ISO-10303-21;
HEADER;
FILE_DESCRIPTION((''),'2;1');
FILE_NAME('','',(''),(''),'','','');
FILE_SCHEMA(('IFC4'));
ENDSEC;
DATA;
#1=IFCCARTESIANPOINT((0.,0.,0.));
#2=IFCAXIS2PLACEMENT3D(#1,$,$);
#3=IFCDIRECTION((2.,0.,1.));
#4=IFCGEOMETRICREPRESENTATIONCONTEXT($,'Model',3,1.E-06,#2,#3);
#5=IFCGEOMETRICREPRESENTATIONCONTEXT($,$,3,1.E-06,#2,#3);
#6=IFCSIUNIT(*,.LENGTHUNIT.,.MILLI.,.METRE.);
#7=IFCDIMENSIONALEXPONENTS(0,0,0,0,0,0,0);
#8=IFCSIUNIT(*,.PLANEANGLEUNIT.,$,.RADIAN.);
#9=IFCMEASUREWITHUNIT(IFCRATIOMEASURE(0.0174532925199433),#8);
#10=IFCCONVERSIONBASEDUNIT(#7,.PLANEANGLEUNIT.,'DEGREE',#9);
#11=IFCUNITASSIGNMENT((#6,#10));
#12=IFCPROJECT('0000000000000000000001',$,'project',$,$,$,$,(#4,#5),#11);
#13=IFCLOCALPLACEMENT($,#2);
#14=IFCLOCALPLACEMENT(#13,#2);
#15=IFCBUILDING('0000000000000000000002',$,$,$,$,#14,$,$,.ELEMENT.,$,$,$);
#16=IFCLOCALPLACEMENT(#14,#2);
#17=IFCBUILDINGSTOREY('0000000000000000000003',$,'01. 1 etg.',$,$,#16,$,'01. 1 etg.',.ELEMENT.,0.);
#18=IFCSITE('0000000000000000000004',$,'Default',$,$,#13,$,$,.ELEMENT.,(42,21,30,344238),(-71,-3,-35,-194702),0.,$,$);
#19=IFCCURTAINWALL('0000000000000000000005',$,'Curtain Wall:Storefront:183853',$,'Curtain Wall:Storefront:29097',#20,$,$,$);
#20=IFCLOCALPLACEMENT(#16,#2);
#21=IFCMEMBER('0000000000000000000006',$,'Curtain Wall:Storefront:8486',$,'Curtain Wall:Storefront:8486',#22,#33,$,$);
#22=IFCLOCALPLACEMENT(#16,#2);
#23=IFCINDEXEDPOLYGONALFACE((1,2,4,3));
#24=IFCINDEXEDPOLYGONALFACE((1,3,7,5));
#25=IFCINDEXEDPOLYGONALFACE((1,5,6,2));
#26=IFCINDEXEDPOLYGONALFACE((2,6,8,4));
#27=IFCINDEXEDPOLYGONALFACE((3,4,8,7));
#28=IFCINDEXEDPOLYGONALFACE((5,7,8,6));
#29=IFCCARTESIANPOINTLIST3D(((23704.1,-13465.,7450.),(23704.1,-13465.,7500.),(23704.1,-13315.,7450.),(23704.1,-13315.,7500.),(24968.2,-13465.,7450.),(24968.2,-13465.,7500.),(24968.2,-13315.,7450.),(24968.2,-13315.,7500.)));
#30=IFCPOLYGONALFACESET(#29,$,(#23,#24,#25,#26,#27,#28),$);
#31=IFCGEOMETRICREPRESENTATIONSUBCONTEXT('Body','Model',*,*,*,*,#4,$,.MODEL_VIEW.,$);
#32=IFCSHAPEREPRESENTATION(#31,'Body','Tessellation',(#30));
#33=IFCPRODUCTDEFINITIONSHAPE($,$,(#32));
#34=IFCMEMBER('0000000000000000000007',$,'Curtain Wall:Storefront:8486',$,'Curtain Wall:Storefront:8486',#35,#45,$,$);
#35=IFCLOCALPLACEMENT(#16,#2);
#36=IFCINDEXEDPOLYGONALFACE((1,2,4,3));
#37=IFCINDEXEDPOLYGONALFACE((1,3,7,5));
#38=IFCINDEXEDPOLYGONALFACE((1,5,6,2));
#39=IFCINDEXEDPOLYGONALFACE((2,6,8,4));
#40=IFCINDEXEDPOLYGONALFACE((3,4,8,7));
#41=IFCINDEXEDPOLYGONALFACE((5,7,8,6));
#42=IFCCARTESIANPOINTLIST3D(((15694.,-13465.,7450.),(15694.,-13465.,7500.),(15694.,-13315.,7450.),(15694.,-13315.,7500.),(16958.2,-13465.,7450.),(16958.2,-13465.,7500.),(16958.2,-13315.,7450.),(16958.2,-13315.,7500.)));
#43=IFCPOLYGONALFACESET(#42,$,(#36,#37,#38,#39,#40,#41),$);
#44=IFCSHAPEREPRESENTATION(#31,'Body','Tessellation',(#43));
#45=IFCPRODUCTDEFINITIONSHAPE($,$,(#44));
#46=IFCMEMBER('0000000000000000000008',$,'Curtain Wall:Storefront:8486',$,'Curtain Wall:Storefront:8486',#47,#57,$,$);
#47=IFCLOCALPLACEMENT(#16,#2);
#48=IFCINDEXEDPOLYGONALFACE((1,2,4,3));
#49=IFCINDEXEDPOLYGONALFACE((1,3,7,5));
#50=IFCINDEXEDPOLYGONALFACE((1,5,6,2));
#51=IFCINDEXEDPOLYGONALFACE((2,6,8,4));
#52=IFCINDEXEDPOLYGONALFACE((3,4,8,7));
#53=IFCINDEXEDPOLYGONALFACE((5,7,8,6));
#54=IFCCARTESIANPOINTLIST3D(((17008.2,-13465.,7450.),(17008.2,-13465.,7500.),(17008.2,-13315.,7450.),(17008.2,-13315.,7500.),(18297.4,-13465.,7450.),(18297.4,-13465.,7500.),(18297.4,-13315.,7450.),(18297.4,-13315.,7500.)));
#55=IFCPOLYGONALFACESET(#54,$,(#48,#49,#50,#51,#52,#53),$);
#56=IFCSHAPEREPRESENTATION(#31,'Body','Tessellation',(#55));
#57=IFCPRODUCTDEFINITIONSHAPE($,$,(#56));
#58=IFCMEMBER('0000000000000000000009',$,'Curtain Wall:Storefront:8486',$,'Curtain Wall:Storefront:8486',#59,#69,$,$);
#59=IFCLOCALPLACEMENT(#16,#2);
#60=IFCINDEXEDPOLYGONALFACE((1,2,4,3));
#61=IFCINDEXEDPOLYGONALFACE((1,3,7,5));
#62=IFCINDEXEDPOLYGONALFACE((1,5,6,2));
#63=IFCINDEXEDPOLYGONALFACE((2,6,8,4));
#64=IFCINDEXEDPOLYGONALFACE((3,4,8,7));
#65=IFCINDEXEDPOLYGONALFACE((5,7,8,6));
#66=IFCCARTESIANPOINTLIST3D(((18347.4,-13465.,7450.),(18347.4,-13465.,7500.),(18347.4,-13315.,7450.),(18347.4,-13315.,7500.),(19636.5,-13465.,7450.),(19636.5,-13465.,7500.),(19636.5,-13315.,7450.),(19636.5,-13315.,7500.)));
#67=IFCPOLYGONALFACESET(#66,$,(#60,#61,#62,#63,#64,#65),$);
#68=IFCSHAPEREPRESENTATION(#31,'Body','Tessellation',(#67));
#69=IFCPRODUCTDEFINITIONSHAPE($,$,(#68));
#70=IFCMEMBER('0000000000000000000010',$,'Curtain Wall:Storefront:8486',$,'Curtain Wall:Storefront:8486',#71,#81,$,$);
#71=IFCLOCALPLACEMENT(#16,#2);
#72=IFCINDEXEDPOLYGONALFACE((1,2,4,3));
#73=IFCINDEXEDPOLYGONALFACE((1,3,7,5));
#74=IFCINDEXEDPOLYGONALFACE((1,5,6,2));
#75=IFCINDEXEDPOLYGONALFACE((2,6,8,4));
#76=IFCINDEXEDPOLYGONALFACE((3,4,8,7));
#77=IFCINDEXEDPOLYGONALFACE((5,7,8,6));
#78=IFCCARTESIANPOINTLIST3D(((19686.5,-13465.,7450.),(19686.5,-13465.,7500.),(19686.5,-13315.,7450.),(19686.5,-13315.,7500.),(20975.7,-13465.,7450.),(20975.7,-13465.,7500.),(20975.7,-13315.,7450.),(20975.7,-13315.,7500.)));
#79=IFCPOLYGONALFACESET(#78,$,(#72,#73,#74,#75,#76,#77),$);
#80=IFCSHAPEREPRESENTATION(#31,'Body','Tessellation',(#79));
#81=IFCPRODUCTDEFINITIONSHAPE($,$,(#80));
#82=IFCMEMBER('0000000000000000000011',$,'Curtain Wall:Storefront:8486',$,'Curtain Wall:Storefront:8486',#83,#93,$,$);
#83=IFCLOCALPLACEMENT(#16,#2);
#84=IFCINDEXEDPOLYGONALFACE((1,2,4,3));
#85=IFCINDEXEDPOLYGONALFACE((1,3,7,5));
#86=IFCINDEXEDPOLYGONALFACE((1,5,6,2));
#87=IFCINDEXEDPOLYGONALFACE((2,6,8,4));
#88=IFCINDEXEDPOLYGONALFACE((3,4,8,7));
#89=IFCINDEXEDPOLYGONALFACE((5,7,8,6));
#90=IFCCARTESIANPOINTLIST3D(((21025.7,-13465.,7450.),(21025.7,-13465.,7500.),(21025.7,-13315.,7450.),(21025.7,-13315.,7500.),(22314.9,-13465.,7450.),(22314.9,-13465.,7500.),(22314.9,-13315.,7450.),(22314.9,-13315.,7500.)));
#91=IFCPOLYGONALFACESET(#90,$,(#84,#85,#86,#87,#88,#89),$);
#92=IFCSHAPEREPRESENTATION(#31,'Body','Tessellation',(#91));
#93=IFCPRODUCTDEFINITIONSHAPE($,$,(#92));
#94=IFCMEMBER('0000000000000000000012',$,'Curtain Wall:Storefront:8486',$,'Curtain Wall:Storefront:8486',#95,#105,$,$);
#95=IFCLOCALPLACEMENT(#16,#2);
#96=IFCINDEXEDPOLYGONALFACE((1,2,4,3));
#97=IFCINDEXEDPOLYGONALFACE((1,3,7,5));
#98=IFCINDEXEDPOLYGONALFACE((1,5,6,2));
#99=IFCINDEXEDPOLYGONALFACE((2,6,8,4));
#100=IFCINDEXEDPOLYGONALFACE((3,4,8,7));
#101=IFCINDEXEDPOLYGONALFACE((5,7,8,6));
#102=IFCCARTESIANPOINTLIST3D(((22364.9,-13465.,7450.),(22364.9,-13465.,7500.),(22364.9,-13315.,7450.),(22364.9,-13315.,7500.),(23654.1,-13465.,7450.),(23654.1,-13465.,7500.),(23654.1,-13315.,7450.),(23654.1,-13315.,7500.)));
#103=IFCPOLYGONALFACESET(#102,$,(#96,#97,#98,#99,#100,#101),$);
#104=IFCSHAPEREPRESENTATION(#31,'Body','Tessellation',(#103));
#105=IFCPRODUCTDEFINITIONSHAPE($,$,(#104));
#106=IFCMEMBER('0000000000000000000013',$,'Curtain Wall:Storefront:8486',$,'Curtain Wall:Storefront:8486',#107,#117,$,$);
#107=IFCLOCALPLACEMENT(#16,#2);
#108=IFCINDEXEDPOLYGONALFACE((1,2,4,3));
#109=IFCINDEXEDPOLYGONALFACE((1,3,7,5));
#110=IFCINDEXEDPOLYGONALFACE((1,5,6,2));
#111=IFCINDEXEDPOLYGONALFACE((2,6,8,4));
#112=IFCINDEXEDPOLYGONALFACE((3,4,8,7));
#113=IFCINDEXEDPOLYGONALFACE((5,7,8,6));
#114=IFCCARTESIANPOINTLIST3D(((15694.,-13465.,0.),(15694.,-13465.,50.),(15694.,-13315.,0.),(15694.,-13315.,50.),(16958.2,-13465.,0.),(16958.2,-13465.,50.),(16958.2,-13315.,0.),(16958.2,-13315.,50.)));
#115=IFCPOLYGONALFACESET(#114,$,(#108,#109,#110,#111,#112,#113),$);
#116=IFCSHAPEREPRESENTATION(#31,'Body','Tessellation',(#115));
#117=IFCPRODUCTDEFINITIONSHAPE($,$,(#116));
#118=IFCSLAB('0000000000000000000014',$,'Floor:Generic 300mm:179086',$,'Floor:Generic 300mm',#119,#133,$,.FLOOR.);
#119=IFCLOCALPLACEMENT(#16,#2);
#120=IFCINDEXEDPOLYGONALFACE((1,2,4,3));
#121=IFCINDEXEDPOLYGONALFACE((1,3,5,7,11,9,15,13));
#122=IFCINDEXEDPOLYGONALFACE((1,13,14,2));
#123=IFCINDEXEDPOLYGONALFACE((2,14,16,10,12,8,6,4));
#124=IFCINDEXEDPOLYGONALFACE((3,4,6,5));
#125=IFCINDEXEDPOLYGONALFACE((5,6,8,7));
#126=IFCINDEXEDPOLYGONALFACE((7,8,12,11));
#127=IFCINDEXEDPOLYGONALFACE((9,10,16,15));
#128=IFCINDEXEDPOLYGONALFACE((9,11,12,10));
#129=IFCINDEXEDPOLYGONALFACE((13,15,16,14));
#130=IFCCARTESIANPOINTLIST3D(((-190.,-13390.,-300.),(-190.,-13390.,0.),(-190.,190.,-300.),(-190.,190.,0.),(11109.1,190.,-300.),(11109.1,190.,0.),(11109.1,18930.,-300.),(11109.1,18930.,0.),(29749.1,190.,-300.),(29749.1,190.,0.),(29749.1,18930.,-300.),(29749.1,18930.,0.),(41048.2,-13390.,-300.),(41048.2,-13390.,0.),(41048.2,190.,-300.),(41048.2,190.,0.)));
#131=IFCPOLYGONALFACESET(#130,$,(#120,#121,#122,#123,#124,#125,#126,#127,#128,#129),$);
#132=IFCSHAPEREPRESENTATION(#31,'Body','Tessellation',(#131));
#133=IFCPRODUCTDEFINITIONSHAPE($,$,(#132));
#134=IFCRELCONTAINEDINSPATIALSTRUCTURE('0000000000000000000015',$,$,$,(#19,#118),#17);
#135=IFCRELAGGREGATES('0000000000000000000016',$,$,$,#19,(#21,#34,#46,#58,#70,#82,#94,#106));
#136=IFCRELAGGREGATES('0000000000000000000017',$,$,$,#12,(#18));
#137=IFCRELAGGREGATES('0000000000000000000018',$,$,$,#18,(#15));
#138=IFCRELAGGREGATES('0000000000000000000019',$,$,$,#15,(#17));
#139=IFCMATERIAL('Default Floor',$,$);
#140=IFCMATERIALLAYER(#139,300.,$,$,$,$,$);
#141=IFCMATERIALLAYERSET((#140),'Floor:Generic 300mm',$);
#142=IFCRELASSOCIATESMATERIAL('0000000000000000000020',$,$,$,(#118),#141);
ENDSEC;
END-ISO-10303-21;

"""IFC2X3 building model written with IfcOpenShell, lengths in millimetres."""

from ifc_helpers import new_model, entity, si_unit, converted_unit, direction, frame, frame_2d, origin, origin_2d_with_axis, place, context, subcontext, project, spatial, polyline, rectangle, outline, extrude, material, layer, layer_set, layer_usage, element, aggregate, save


model = new_model("IFC2X3")

# Units and contexts
model_context = context("Model", 3, precision=1e-06, world=origin(), true_north=direction((2.0, 0.0, 1.0)))
context_of_model = context(None, 3, precision=1e-06, world=origin(), true_north=direction((2.0, 0.0, 1.0)))
body_context = subcontext(model_context, "Body", "Model", "MODEL_VIEW")
ifc_project = project(units=[si_unit("LENGTHUNIT", "METRE", prefix="MILLI"), converted_unit("PLANEANGLEUNIT", "DEGREE", entity("IfcRatioMeasure", 0.0174532925199433), si_unit("PLANEANGLEUNIT", "RADIAN"), dimensions=[0, 0, 0, 0, 0, 0, 0])], contexts=[model_context, context_of_model])

# Site, building, storey
site_placement = place(None, origin())
site = spatial("IfcSite", under=ifc_project, at=site_placement, Name="Default", CompositionType="ELEMENT", RefLatitude=(42, 21, 30, 344238), RefLongitude=(-71, -3, -35, -194702), RefElevation=0.0)
building_placement = place(site_placement, origin())
building = spatial("IfcBuilding", under=site, at=building_placement, CompositionType="ELEMENT")
storey_placement = place(building_placement, origin())
storey = spatial("IfcBuildingStorey", under=building, at=storey_placement, Name="01. 1 etg.", LongName="01. 1 etg.", CompositionType="ELEMENT", Elevation=0.0)

# Curtain wall, members
curtain_wall_placement = place(storey_placement, origin())
curtain_wall = element("IfcCurtainWall", 1, at=curtain_wall_placement, inside=storey, Name="Curtain Wall:Storefront:183853", ObjectType="Curtain Wall:Storefront:29097")
member_1_placement = place(storey_placement, origin())
member_1 = element("IfcMember", 2, at=member_1_placement, Name="Curtain Wall:Storefront:8486", ObjectType="Curtain Wall:Storefront:8486", context=body_context, shape_type="SweptSolid", body=[
    extrude(rectangle(XDim=1264.2, YDim=150.0, at=origin_2d_with_axis()), frame((24336.1, -13390.0, 7450.0), z_axis=(0.0, 0.0, 1.0), x_axis=(-1.0, 0.0, 0.0)), (0.0, 0.0, 1.0), 50.0),
])
member_2_placement = place(storey_placement, origin())
member_2 = element("IfcMember", 3, at=member_2_placement, Name="Curtain Wall:Storefront:8486", ObjectType="Curtain Wall:Storefront:8486", context=body_context, shape_type="SweptSolid", body=[
    extrude(rectangle(XDim=1264.2, YDim=150.0, at=origin_2d_with_axis()), frame((16326.1, -13390.0, 7450.0), z_axis=(0.0, 0.0, 1.0), x_axis=(-1.0, 0.0, 0.0)), (0.0, 0.0, 1.0), 50.0),
])
member_3_placement = place(storey_placement, origin())
member_3 = element("IfcMember", 4, at=member_3_placement, Name="Curtain Wall:Storefront:8486", ObjectType="Curtain Wall:Storefront:8486", context=body_context, shape_type="SweptSolid", body=[
    extrude(rectangle(XDim=1289.2, YDim=150.0, at=frame_2d((0.0, 0.0), x_axis=(1.0, 0.0))), frame((17652.8, -13390.0, 7450.0), z_axis=(0.0, 0.0, 1.0), x_axis=(-1.0, 0.0, 0.0)), (0.0, 0.0, 1.0), 50.0),
])
member_4_placement = place(storey_placement, origin())
member_4 = element("IfcMember", 5, at=member_4_placement, Name="Curtain Wall:Storefront:8486", ObjectType="Curtain Wall:Storefront:8486", context=body_context, shape_type="SweptSolid", body=[
    extrude(rectangle(XDim=1289.2, YDim=150.0, at=frame_2d((0.0, 0.0), x_axis=(1.0, 0.0))), frame((18991.9, -13390.0, 7450.0), z_axis=(0.0, 0.0, 1.0), x_axis=(-1.0, 0.0, 0.0)), (0.0, 0.0, 1.0), 50.0),
])
member_5_placement = place(storey_placement, origin())
member_5 = element("IfcMember", 6, at=member_5_placement, Name="Curtain Wall:Storefront:8486", ObjectType="Curtain Wall:Storefront:8486", context=body_context, shape_type="SweptSolid", body=[
    extrude(rectangle(XDim=1289.2, YDim=150.0, at=origin_2d_with_axis()), frame((20331.1, -13390.0, 7450.0), z_axis=(0.0, 0.0, 1.0), x_axis=(-1.0, 0.0, 0.0)), (0.0, 0.0, 1.0), 50.0),
])
member_6_placement = place(storey_placement, origin())
member_6 = element("IfcMember", 7, at=member_6_placement, Name="Curtain Wall:Storefront:8486", ObjectType="Curtain Wall:Storefront:8486", context=body_context, shape_type="SweptSolid", body=[
    extrude(rectangle(XDim=1289.2, YDim=150.0, at=origin_2d_with_axis()), frame((21670.3, -13390.0, 7450.0), z_axis=(0.0, 0.0, 1.0), x_axis=(-1.0, 0.0, 0.0)), (0.0, 0.0, 1.0), 50.0),
])
member_7_placement = place(storey_placement, origin())
member_7 = element("IfcMember", 8, at=member_7_placement, Name="Curtain Wall:Storefront:8486", ObjectType="Curtain Wall:Storefront:8486", context=body_context, shape_type="SweptSolid", body=[
    extrude(rectangle(XDim=1289.2, YDim=150.0, at=origin_2d_with_axis()), frame((23009.5, -13390.0, 7450.0), z_axis=(0.0, 0.0, 1.0), x_axis=(-1.0, 0.0, 0.0)), (0.0, 0.0, 1.0), 50.0),
])
member_8_placement = place(storey_placement, origin())
member_8 = element("IfcMember", 9, at=member_8_placement, Name="Curtain Wall:Storefront:8486", ObjectType="Curtain Wall:Storefront:8486", context=body_context, shape_type="SweptSolid", body=[
    extrude(rectangle(XDim=1264.2, YDim=150.0, at=origin_2d_with_axis()), frame((16326.1, -13390.0, 0.0)), (0.0, 0.0, 1.0), 50.0),
])
aggregate(curtain_wall, [member_1, member_2, member_3, member_4, member_5, member_6, member_7, member_8])

# Slab
ifc_material_1 = material(Name="Default Floor")
ifc_layer_1 = layer(ifc_material_1, 300.0)
ifc_layer_set_1 = layer_set([ifc_layer_1], Name="Floor:Generic 300mm")
ifc_layer_usage_1 = layer_usage(ifc_layer_set_1, "AXIS3", "POSITIVE", 0.0)
slab_placement = place(storey_placement, origin())
element("IfcSlab", 10, at=slab_placement, inside=storey, material=ifc_layer_usage_1, Name="Floor:Generic 300mm:179086", ObjectType="Floor:Generic 300mm", PredefinedType="FLOOR", context=body_context, shape_type="SweptSolid", body=[
    extrude(outline(polyline([(9320.0, -2580.0), (9320.0, 16160.0), (-9320.0, 16160.0), (-9320.0, -2580.0), (-20619.1, -2580.0), (-20619.1, -16160.0), (20619.1, -16160.0), (20619.1, -2580.0), (9320.0, -2580.0)])), frame((20429.1, 2770.0, 0.0), z_axis=(0.0, 0.0, -1.0), x_axis=(-1.0, 0.0, 0.0)), (0.0, 0.0, 1.0), 300.0),
])

save(model, "model.ifc")
